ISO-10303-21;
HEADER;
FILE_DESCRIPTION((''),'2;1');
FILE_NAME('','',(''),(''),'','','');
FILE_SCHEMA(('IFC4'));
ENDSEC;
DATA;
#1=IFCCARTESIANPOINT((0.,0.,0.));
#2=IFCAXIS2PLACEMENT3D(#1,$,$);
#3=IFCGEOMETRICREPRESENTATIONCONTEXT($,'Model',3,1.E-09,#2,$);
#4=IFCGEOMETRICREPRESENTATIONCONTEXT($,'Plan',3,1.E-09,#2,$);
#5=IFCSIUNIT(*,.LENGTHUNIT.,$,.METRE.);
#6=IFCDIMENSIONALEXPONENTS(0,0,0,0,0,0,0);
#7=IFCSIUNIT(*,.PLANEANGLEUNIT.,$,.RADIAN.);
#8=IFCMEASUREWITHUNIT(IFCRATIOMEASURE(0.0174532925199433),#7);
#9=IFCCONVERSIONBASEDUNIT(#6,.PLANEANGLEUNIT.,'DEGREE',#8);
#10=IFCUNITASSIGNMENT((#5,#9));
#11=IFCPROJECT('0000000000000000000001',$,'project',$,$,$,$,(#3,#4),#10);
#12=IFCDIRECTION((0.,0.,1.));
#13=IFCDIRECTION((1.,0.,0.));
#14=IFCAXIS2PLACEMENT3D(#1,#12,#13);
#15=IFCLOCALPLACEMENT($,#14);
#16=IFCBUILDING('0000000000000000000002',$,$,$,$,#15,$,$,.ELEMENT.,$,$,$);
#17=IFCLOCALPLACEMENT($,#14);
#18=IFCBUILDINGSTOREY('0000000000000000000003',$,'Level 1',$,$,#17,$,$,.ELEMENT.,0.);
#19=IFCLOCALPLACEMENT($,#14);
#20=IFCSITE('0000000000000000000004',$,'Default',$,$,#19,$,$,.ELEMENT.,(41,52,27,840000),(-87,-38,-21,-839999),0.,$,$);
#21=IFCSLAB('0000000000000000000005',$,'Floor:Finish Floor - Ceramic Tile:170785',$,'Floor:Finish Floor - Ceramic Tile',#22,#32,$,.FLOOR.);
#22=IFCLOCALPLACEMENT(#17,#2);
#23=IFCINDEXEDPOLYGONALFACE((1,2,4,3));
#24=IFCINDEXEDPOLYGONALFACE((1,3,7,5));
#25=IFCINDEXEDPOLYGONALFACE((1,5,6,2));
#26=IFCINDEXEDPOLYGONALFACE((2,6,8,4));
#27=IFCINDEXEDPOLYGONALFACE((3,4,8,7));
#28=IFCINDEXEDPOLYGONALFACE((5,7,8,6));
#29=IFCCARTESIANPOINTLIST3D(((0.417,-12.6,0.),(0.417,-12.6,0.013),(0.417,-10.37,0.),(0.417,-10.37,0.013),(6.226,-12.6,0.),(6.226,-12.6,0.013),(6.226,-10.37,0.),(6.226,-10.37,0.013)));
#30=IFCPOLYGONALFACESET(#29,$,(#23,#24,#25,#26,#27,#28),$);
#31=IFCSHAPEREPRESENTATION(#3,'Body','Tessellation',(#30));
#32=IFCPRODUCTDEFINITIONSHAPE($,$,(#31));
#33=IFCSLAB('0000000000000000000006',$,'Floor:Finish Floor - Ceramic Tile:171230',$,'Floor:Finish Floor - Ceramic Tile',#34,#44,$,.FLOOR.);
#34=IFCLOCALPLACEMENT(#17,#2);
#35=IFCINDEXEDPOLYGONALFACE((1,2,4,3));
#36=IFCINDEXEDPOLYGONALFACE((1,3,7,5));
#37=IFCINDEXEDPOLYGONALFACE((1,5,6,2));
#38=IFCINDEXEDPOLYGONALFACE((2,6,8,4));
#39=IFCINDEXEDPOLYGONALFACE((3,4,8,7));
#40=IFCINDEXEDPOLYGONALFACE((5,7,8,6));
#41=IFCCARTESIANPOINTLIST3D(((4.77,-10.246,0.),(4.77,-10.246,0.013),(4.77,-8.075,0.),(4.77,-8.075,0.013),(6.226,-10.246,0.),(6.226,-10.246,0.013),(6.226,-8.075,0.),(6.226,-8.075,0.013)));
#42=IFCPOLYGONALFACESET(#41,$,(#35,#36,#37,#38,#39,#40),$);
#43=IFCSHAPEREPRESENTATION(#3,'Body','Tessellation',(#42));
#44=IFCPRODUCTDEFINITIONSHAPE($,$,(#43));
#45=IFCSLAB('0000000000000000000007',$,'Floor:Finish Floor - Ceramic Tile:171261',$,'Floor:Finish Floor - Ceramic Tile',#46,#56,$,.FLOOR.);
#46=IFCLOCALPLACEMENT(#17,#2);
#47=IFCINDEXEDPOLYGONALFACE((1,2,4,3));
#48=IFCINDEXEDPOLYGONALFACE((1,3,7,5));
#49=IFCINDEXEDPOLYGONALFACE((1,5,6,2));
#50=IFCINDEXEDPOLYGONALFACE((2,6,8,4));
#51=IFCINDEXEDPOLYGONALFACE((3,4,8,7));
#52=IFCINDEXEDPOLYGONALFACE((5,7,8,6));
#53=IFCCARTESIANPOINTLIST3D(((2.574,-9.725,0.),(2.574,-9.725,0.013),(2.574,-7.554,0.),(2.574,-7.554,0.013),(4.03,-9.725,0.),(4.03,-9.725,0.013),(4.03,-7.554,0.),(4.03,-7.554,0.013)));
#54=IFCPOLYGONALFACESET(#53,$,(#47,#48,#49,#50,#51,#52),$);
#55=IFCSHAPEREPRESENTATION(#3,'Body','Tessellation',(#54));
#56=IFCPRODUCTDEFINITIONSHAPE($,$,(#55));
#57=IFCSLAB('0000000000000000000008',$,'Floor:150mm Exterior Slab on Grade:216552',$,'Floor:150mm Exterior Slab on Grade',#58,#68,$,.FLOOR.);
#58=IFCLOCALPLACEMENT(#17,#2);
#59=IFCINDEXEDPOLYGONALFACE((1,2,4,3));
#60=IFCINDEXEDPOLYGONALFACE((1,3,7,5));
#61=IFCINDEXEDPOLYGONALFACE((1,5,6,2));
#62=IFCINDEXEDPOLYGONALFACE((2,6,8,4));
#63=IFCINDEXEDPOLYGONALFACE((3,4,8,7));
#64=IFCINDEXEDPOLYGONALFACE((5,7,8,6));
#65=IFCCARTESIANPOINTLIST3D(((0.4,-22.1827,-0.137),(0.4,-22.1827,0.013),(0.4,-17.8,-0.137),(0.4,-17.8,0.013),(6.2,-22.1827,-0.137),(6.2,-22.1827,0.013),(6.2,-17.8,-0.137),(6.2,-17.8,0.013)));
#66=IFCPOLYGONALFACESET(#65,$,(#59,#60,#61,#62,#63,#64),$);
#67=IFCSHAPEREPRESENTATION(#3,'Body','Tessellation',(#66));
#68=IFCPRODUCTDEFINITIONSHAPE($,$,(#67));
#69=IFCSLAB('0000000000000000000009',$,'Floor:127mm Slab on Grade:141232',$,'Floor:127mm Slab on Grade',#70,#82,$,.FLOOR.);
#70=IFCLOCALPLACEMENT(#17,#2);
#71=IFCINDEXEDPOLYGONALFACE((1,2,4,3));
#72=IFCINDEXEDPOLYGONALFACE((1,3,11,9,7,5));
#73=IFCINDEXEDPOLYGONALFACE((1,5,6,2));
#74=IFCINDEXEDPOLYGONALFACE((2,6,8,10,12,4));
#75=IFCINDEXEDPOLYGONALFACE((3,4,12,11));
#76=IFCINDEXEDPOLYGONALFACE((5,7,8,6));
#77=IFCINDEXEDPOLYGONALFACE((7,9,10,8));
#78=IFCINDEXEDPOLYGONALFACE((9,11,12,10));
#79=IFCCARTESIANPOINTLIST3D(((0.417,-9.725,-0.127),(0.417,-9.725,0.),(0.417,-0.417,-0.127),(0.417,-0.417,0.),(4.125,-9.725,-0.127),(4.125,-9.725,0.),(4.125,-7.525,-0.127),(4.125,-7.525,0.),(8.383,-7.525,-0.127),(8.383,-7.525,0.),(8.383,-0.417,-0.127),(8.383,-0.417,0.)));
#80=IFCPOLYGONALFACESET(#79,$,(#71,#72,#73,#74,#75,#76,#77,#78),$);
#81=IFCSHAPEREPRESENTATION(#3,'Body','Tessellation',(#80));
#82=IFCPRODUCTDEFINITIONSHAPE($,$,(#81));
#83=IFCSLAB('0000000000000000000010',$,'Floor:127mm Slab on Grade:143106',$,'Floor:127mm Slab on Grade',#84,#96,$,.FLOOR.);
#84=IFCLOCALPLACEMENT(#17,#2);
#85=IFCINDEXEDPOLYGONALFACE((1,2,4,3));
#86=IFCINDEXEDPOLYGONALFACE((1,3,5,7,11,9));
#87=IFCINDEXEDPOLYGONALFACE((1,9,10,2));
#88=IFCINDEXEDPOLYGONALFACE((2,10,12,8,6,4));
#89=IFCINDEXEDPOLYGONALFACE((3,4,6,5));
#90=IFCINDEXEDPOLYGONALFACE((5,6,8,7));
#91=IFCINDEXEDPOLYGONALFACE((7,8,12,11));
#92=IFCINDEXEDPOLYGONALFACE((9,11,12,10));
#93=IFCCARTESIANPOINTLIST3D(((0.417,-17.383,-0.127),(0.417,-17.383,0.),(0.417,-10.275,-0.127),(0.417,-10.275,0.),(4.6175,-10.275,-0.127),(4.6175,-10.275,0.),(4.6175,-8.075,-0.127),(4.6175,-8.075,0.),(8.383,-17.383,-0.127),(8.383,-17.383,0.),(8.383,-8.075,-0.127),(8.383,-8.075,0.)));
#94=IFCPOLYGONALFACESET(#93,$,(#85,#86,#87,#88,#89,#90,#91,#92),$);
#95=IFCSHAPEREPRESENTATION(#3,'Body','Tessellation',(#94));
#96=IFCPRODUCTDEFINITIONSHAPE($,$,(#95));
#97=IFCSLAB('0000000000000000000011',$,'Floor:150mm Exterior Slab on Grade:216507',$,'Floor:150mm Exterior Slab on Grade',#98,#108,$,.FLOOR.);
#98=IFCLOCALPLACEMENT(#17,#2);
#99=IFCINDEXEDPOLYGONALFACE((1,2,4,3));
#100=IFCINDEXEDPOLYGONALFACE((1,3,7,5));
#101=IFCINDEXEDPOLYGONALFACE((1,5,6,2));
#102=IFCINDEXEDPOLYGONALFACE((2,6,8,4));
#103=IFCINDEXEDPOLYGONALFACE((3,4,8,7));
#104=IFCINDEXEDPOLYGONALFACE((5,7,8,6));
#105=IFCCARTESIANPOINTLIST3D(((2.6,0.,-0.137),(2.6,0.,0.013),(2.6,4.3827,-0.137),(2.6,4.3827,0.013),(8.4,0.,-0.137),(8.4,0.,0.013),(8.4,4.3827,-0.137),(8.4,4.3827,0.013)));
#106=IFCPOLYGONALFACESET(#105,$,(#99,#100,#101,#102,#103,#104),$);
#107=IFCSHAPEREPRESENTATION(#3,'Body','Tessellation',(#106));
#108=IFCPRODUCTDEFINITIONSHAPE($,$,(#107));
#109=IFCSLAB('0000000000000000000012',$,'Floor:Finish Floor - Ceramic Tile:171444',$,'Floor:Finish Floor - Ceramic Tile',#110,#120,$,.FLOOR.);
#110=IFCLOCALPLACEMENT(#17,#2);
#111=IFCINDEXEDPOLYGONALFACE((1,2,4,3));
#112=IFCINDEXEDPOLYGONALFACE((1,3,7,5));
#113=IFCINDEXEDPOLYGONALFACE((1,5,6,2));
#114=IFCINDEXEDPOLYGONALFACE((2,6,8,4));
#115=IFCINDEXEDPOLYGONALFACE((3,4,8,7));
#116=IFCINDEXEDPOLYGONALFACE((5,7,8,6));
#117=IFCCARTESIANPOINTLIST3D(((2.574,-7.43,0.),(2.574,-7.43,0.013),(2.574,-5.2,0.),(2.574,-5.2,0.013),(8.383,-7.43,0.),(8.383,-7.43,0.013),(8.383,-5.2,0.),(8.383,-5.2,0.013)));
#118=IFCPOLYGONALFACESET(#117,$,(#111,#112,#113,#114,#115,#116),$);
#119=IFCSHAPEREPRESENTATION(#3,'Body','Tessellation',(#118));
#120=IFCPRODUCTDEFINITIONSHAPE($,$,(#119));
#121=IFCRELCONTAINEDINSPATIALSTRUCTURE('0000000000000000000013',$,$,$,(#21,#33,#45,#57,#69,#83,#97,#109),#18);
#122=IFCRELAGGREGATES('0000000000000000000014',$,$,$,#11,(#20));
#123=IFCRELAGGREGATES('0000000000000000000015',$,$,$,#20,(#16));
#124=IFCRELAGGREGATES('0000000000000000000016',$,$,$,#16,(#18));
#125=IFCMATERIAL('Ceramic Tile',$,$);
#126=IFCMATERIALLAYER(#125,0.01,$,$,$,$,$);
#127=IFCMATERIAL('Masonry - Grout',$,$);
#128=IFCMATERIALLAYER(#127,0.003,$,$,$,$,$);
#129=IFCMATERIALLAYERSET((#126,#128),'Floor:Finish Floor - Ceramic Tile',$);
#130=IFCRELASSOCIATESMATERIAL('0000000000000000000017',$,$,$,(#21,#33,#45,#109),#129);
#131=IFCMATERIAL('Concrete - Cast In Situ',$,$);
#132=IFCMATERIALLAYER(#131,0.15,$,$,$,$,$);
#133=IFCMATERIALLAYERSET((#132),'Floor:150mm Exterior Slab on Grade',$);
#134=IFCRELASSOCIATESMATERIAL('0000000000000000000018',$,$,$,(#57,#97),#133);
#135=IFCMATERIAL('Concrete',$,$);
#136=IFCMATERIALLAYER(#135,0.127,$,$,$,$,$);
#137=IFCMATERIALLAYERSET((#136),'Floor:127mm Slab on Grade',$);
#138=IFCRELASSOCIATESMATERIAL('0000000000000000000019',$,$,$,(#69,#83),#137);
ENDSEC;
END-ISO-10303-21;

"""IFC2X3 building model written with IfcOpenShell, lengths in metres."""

from ifc_helpers import new_model, entity, si_unit, converted_unit, frame, frame_2d, origin, origin_with_axes, origin_2d_with_axis, place, context, project, spatial, polyline, rectangle, outline, extrude, material, layer, layer_set, layer_usage, element, save


model = new_model("IFC2X3")

# Units and contexts
model_context = context("Model", 3, precision=1e-09, world=origin())
plan_context = context("Plan", 3, precision=1e-09, world=origin())
ifc_project = project(units=[si_unit("LENGTHUNIT", "METRE"), converted_unit("PLANEANGLEUNIT", "DEGREE", entity("IfcRatioMeasure", 0.0174532925199433), si_unit("PLANEANGLEUNIT", "RADIAN"), dimensions=[0, 0, 0, 0, 0, 0, 0])], contexts=[model_context, plan_context])

# Site, building, storey
site_placement = place(None, origin_with_axes())
site = spatial("IfcSite", under=ifc_project, at=site_placement, Name="Default", CompositionType="ELEMENT", RefLatitude=(41, 52, 27, 840000), RefLongitude=(-87, -38, -21, -839999), RefElevation=0.0)
building_placement = place(None, origin_with_axes())
building = spatial("IfcBuilding", under=site, at=building_placement, CompositionType="ELEMENT")
storey_placement = place(None, origin_with_axes())
storey = spatial("IfcBuildingStorey", under=building, at=storey_placement, Name="Level 1", CompositionType="ELEMENT", Elevation=0.0)

# Slabs
ifc_material_1 = material(Name="Ceramic Tile")
ifc_layer_1 = layer(ifc_material_1, 0.01)
ifc_material_2 = material(Name="Masonry - Grout")
ifc_layer_2 = layer(ifc_material_2, 0.003)
ifc_layer_set_1 = layer_set([ifc_layer_1, ifc_layer_2], Name="Floor:Finish Floor - Ceramic Tile")
ifc_layer_usage_1 = layer_usage(ifc_layer_set_1, "AXIS3", "POSITIVE", 0.0)
slab_1_placement = place(None, frame((0.417, -12.6, 0.0), z_axis=(0.0, 0.0, 1.0), x_axis=(1.0, 0.0, 0.0)))
element("IfcSlab", 1, at=slab_1_placement, inside=storey, material=ifc_layer_usage_1, Name="Floor:Finish Floor - Ceramic Tile:170785", ObjectType="Floor:Finish Floor - Ceramic Tile", PredefinedType="FLOOR", context=model_context, shape_type="SweptSolid", body=[
    extrude(rectangle(XDim=5.809, YDim=2.23, at=frame_2d((0.0, 0.0), x_axis=(-1.0, 0.0))), frame((2.9045, 1.115, 0.013), z_axis=(0.0, 0.0, -1.0), x_axis=(-1.0, 0.0, 0.0)), (0.0, 0.0, 1.0), 0.013),
])
ifc_layer_usage_2 = layer_usage(ifc_layer_set_1, "AXIS3", "POSITIVE", 0.0)
slab_2_placement = place(None, frame((4.77, -10.246, 0.0), z_axis=(0.0, 0.0, 1.0), x_axis=(1.0, 0.0, 0.0)))
element("IfcSlab", 2, at=slab_2_placement, inside=storey, material=ifc_layer_usage_2, Name="Floor:Finish Floor - Ceramic Tile:171230", ObjectType="Floor:Finish Floor - Ceramic Tile", PredefinedType="FLOOR", context=model_context, shape_type="SweptSolid", body=[
    extrude(rectangle(XDim=1.456, YDim=2.171, at=frame_2d((0.0, 0.0), x_axis=(-1.0, 0.0))), frame((0.728, 1.0855, 0.013), z_axis=(0.0, 0.0, -1.0), x_axis=(-1.0, 0.0, 0.0)), (0.0, 0.0, 1.0), 0.013),
])
ifc_layer_usage_3 = layer_usage(ifc_layer_set_1, "AXIS3", "POSITIVE", 0.0)
slab_3_placement = place(None, frame((2.574, -9.725, 0.0), z_axis=(0.0, 0.0, 1.0), x_axis=(1.0, 0.0, 0.0)))
element("IfcSlab", 3, at=slab_3_placement, inside=storey, material=ifc_layer_usage_3, Name="Floor:Finish Floor - Ceramic Tile:171261", ObjectType="Floor:Finish Floor - Ceramic Tile", PredefinedType="FLOOR", context=model_context, shape_type="SweptSolid", body=[
    extrude(rectangle(XDim=2.171, YDim=1.456, at=frame_2d((0.0, 0.0), x_axis=(0.0, -1.0))), frame((0.728, 1.0855, 0.013), z_axis=(0.0, 0.0, -1.0), x_axis=(-1.0, 0.0, 0.0)), (0.0, 0.0, 1.0), 0.013),
])
ifc_material_3 = material(Name="Concrete - Cast In Situ")
ifc_layer_3 = layer(ifc_material_3, 0.15)
ifc_layer_set_2 = layer_set([ifc_layer_3], Name="Floor:150mm Exterior Slab on Grade")
ifc_layer_usage_4 = layer_usage(ifc_layer_set_2, "AXIS3", "POSITIVE", 0.0)
slab_4_placement = place(None, frame((0.4, -22.1827, -0.137), z_axis=(0.0, 0.0, 1.0), x_axis=(1.0, 0.0, 0.0)))
element("IfcSlab", 4, at=slab_4_placement, inside=storey, material=ifc_layer_usage_4, Name="Floor:150mm Exterior Slab on Grade:216552", ObjectType="Floor:150mm Exterior Slab on Grade", PredefinedType="FLOOR", context=model_context, shape_type="SweptSolid", body=[
    extrude(rectangle(XDim=5.8, YDim=4.3827, at=origin_2d_with_axis()), frame((2.9, 2.1914, 0.15), z_axis=(0.0, 0.0, -1.0), x_axis=(-1.0, 0.0, 0.0)), (0.0, 0.0, 1.0), 0.15),
])
ifc_material_4 = material(Name="Concrete")
ifc_layer_4 = layer(ifc_material_4, 0.127)
ifc_layer_set_3 = layer_set([ifc_layer_4], Name="Floor:127mm Slab on Grade")
ifc_layer_usage_5 = layer_usage(ifc_layer_set_3, "AXIS3", "POSITIVE", 0.0)
slab_5_placement = place(None, frame((0.417, -9.725, -0.127), z_axis=(0.0, 0.0, 1.0), x_axis=(1.0, 0.0, 0.0)))
element("IfcSlab", 5, at=slab_5_placement, inside=storey, material=ifc_layer_usage_5, Name="Floor:127mm Slab on Grade:141232", ObjectType="Floor:127mm Slab on Grade", PredefinedType="FLOOR", context=model_context, shape_type="SweptSolid", body=[
    extrude(outline(polyline([(-3.983, 4.654), (-3.983, -2.454), (0.275, -2.454), (0.275, -4.654), (3.983, -4.654), (3.983, 4.654), (-3.983, 4.654)])), frame((3.983, 4.654, 0.127), z_axis=(0.0, 0.0, -1.0), x_axis=(-1.0, 0.0, 0.0)), (0.0, 0.0, 1.0), 0.127),
])
ifc_layer_usage_6 = layer_usage(ifc_layer_set_3, "AXIS3", "POSITIVE", 0.0)
slab_6_placement = place(None, frame((0.417, -17.383, -0.127), z_axis=(0.0, 0.0, 1.0), x_axis=(1.0, 0.0, 0.0)))
element("IfcSlab", 6, at=slab_6_placement, inside=storey, material=ifc_layer_usage_6, Name="Floor:127mm Slab on Grade:143106", ObjectType="Floor:127mm Slab on Grade", PredefinedType="FLOOR", context=model_context, shape_type="SweptSolid", body=[
    extrude(outline(polyline([(-3.983, 4.654), (-3.983, -4.654), (3.983, -4.654), (3.983, 2.454), (-0.2175, 2.454), (-0.2175, 4.654), (-3.983, 4.654)])), frame((3.983, 4.654, 0.127), z_axis=(0.0, 0.0, -1.0), x_axis=(-1.0, 0.0, 0.0)), (0.0, 0.0, 1.0), 0.127),
])
ifc_layer_usage_7 = layer_usage(ifc_layer_set_2, "AXIS3", "POSITIVE", 0.0)
slab_7_placement = place(None, frame((2.6, 0.0, -0.137), z_axis=(0.0, 0.0, 1.0), x_axis=(1.0, 0.0, 0.0)))
element("IfcSlab", 7, at=slab_7_placement, inside=storey, material=ifc_layer_usage_7, Name="Floor:150mm Exterior Slab on Grade:216507", ObjectType="Floor:150mm Exterior Slab on Grade", PredefinedType="FLOOR", context=model_context, shape_type="SweptSolid", body=[
    extrude(rectangle(XDim=5.8, YDim=4.3827, at=frame_2d((0.0, 0.0), x_axis=(-1.0, 0.0))), frame((2.9, 2.1914, 0.15), z_axis=(0.0, 0.0, -1.0), x_axis=(-1.0, 0.0, 0.0)), (0.0, 0.0, 1.0), 0.15),
])
ifc_layer_usage_8 = layer_usage(ifc_layer_set_1, "AXIS3", "POSITIVE", 0.0)
slab_8_placement = place(None, frame((2.574, -7.43, 0.0), z_axis=(0.0, 0.0, 1.0), x_axis=(1.0, 0.0, 0.0)))
element("IfcSlab", 8, at=slab_8_placement, inside=storey, material=ifc_layer_usage_8, Name="Floor:Finish Floor - Ceramic Tile:171444", ObjectType="Floor:Finish Floor - Ceramic Tile", PredefinedType="FLOOR", context=model_context, shape_type="SweptSolid", body=[
    extrude(rectangle(XDim=5.809, YDim=2.23, at=frame_2d((0.0, 0.0), x_axis=(-1.0, 0.0))), frame((2.9045, 1.115, 0.013), z_axis=(0.0, 0.0, -1.0), x_axis=(-1.0, 0.0, 0.0)), (0.0, 0.0, 1.0), 0.013),
])

save(model, "model.ifc")
